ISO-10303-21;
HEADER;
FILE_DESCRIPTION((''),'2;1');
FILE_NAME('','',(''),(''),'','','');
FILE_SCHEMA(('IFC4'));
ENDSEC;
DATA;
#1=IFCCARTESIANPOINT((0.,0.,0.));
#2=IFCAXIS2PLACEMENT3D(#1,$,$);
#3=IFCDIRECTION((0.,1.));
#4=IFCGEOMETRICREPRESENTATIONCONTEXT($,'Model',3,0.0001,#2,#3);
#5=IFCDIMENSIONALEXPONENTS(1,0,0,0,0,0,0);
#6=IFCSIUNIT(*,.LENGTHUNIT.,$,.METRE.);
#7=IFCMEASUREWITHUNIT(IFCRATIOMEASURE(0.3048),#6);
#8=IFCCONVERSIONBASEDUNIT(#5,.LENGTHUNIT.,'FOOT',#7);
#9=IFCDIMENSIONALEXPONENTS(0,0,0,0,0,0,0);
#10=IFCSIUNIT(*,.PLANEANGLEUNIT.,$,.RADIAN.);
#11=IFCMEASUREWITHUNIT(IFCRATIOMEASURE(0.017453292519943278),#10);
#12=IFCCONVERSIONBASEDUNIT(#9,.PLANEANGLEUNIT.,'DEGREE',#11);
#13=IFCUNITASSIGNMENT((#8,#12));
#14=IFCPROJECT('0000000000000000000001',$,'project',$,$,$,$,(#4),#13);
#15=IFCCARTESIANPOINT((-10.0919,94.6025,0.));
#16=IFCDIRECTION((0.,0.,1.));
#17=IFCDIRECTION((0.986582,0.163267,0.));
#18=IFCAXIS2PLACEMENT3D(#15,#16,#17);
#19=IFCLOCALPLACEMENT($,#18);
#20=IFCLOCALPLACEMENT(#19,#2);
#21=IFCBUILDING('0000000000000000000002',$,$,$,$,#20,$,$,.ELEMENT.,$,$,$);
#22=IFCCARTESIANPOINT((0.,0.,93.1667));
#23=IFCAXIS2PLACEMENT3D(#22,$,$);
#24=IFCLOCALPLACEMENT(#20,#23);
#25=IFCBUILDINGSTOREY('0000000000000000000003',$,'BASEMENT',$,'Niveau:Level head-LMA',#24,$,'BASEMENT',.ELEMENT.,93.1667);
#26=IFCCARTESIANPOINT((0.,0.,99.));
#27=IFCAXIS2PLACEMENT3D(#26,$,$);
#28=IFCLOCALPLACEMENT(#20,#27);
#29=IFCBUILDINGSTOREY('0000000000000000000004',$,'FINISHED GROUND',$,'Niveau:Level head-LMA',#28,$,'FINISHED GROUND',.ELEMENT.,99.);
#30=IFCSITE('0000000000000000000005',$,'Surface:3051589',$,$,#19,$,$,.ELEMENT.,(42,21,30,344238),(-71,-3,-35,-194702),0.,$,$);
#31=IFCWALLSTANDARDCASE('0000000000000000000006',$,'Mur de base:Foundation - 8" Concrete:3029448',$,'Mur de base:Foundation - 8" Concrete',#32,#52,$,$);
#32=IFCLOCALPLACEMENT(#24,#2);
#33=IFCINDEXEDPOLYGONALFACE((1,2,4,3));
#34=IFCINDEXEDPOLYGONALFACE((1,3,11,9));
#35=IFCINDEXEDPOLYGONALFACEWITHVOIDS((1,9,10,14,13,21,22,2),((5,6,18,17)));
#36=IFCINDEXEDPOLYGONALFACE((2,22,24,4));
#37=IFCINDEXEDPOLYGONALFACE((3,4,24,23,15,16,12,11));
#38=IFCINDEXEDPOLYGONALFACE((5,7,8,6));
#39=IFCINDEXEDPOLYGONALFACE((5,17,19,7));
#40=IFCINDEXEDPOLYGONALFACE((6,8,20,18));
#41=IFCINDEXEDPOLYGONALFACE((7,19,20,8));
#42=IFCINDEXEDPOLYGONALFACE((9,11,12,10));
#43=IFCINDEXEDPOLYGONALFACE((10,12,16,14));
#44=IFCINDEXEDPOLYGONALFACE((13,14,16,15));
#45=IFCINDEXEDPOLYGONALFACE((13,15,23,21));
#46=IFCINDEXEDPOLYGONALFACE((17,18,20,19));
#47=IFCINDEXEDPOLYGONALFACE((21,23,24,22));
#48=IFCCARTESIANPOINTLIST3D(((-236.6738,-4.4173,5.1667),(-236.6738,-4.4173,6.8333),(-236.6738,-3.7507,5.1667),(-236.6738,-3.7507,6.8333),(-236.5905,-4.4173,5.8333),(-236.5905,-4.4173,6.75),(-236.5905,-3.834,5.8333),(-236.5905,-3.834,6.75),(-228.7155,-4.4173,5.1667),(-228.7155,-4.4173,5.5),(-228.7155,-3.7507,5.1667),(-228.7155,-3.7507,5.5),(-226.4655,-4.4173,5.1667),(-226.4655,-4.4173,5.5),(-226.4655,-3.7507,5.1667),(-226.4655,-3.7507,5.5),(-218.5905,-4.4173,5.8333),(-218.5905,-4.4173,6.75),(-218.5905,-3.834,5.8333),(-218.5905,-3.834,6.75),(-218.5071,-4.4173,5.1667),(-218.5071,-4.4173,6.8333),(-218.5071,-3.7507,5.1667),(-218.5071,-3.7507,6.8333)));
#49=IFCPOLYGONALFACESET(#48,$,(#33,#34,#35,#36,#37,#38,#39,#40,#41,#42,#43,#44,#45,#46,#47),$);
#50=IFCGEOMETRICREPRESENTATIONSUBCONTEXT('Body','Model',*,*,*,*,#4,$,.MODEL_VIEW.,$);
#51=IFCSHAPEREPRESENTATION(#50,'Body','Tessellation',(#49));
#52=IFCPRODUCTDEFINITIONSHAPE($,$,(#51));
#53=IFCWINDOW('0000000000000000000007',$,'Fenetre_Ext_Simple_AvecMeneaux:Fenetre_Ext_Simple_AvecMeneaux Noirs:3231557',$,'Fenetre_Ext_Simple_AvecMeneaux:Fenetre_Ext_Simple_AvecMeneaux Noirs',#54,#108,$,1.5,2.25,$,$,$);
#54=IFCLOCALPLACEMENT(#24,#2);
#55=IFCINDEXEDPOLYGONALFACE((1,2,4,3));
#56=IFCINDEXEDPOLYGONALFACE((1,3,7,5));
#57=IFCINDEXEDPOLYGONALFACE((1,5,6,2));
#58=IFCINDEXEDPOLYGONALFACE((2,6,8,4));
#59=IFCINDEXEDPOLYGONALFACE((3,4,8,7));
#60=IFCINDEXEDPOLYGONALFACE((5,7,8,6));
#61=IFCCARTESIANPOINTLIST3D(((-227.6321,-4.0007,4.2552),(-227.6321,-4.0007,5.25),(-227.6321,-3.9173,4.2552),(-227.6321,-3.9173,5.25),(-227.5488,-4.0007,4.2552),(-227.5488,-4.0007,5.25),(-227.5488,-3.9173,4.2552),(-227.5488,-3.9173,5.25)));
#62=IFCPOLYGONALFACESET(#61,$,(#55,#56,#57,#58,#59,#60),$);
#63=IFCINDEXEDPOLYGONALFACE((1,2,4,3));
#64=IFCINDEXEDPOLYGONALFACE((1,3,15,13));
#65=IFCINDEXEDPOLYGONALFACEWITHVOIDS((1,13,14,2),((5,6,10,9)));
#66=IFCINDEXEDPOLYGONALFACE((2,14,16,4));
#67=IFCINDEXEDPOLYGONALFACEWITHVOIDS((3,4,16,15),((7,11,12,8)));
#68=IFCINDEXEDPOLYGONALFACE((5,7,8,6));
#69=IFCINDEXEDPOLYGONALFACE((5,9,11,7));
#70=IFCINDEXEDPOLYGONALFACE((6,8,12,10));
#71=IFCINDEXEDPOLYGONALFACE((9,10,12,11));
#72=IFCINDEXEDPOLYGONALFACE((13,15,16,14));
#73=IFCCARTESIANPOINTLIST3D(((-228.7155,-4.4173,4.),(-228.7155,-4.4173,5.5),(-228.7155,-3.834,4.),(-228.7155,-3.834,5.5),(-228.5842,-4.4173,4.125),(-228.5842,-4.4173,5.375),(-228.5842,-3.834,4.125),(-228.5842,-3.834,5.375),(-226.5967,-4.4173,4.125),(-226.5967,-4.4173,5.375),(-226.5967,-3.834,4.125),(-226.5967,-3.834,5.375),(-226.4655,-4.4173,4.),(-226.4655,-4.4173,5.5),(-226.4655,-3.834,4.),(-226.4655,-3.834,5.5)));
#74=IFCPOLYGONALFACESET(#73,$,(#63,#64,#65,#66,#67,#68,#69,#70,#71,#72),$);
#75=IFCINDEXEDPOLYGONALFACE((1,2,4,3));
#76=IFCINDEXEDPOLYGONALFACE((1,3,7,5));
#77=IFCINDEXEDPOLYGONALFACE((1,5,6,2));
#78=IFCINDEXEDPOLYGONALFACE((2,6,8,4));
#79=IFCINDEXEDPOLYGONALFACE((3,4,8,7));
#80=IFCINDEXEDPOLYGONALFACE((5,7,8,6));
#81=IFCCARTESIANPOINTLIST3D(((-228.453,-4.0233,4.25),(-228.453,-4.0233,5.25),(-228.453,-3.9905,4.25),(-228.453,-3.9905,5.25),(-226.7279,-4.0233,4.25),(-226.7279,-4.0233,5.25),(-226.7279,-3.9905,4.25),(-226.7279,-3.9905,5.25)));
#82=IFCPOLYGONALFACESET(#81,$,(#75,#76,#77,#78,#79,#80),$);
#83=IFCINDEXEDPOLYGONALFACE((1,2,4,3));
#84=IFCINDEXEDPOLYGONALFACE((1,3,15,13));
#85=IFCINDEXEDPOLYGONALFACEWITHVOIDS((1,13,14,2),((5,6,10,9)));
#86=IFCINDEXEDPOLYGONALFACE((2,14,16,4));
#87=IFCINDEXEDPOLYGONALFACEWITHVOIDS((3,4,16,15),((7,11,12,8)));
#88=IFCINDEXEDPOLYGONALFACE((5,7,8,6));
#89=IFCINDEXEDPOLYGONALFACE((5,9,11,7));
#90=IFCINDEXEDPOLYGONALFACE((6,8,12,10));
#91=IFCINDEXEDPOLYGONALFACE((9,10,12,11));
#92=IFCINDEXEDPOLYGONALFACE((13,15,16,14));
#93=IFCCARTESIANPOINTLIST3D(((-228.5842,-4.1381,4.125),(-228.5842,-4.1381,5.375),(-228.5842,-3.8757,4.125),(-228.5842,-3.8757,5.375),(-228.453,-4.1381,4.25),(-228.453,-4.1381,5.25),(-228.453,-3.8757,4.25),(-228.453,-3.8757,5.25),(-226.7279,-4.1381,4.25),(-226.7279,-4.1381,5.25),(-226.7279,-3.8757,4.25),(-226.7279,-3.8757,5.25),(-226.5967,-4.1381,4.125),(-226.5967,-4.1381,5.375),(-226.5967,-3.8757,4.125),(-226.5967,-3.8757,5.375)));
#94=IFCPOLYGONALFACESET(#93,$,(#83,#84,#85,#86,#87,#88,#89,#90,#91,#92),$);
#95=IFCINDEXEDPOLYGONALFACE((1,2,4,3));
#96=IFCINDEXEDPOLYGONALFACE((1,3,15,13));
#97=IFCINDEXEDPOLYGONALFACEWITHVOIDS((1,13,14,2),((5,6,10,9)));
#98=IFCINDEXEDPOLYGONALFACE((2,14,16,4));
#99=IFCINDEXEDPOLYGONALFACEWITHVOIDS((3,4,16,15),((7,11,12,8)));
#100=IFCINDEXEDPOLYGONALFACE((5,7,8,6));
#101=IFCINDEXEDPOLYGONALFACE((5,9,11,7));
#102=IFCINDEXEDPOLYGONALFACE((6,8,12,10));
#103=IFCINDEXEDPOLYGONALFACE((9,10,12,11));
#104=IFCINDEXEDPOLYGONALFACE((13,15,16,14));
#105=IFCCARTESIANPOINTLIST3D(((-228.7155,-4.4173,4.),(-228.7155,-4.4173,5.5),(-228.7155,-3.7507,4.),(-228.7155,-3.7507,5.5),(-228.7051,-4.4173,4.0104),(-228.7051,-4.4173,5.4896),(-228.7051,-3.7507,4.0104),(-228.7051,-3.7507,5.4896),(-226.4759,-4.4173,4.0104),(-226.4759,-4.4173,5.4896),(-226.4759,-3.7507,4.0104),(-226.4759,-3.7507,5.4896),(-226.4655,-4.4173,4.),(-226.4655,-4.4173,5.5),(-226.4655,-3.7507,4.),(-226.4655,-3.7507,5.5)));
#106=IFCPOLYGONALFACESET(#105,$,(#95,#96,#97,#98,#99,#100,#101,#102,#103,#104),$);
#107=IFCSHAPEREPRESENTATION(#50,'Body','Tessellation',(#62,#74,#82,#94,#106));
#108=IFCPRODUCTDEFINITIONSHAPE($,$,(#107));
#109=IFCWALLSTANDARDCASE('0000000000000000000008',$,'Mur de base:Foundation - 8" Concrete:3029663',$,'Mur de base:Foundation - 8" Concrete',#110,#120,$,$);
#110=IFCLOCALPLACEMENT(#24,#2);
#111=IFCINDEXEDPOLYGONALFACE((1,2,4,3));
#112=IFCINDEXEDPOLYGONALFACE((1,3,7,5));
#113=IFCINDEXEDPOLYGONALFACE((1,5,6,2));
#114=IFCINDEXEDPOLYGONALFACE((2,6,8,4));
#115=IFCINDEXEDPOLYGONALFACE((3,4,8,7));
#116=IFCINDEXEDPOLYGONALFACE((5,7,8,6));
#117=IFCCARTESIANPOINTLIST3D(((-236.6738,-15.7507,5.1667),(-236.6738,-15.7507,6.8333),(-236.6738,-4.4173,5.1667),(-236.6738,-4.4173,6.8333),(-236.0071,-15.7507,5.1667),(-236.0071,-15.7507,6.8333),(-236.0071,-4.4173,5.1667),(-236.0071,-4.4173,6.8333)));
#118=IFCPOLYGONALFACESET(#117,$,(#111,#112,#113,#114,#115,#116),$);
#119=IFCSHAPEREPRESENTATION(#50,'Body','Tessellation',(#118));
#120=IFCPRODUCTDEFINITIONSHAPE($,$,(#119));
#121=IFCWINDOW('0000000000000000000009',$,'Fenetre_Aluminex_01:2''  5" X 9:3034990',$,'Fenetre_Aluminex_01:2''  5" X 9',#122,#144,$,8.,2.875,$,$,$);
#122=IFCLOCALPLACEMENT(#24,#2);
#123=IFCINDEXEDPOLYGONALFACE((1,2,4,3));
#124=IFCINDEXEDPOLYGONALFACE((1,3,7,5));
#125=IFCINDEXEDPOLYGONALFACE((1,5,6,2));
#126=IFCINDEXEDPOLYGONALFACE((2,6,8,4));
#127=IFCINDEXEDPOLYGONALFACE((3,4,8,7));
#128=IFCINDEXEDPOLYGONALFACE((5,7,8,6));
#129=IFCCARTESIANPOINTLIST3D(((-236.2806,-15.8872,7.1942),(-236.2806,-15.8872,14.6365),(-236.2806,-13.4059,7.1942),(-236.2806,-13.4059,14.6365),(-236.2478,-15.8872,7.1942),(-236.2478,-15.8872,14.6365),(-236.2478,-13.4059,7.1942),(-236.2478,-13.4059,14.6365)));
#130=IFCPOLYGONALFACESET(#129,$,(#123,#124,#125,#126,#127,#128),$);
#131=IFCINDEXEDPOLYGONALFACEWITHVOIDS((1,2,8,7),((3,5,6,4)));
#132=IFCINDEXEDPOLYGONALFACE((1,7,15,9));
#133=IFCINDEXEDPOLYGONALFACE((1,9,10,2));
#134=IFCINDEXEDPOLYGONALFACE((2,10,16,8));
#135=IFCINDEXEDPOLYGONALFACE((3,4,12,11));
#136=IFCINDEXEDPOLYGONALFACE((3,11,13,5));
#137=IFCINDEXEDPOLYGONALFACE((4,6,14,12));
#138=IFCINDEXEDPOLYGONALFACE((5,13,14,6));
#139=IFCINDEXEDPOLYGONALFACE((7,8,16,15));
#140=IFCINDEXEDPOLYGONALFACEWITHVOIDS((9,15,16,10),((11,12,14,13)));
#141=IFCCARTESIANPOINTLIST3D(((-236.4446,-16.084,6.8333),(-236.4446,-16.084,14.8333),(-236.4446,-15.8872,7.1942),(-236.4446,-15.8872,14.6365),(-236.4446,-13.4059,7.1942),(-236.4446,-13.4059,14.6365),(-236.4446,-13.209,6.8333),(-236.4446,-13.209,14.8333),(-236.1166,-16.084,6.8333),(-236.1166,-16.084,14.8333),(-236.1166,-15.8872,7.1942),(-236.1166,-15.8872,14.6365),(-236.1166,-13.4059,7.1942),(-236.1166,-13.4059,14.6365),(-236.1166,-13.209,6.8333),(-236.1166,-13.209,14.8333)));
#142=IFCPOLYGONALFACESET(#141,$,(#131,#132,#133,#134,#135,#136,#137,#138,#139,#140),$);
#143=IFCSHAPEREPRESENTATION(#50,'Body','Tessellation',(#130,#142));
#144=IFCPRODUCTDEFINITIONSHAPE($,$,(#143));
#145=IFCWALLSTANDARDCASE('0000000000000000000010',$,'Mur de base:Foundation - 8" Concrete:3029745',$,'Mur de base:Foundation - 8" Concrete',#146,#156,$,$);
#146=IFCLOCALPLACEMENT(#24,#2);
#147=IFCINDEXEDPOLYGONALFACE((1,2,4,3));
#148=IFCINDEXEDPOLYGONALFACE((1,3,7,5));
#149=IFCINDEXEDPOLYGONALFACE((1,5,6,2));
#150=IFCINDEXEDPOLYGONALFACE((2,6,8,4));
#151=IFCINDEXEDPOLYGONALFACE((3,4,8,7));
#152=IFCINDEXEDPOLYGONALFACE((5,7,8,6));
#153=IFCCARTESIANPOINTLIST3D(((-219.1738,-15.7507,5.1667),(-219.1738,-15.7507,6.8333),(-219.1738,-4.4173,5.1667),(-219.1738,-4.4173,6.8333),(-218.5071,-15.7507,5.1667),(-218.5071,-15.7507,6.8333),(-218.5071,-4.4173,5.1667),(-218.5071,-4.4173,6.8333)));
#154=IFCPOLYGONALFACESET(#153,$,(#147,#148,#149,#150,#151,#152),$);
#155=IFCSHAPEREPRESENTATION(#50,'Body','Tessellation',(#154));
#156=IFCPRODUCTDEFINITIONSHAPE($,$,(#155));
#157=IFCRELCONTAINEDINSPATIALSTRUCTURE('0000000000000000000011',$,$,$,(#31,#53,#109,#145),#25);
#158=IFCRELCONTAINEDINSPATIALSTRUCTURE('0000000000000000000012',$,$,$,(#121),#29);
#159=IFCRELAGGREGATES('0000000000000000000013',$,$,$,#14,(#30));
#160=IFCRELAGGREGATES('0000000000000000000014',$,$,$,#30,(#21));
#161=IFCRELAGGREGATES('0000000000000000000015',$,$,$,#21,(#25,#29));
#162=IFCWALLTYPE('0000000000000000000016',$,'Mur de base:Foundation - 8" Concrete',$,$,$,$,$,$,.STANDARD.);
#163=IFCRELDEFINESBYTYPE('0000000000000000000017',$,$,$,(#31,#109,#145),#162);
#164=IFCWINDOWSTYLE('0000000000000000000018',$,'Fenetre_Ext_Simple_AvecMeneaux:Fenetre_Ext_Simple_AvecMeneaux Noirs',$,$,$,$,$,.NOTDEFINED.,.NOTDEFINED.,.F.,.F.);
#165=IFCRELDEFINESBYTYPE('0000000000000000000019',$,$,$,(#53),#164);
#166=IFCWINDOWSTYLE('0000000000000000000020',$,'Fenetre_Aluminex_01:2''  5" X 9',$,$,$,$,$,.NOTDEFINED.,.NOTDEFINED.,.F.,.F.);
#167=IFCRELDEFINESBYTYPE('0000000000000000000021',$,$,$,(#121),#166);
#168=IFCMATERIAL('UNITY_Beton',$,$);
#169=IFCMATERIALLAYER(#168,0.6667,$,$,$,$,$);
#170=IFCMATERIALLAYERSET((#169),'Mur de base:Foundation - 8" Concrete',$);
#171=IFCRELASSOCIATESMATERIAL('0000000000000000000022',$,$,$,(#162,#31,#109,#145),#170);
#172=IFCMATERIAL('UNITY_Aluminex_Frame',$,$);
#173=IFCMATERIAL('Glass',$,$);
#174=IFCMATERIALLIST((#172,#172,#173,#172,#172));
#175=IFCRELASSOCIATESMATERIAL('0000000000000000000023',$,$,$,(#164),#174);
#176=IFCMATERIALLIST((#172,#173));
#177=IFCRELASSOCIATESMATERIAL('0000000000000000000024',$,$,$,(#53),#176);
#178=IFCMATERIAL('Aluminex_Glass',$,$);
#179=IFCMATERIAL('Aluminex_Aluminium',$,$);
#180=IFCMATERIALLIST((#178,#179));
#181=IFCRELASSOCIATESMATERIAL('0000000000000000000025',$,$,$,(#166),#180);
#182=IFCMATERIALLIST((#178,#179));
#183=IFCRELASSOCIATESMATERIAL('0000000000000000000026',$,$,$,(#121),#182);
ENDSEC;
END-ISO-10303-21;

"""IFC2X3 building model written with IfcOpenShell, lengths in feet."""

from ifc_helpers import new_model, entity, si_unit, converted_unit, direction, frame, frame_2d, origin, place, context, subcontext, project, spatial, polyline, rectangle, outline, extrude, source, transform, mapped, material, material_list, layer, layer_set, layer_usage, type_object, type_shapes, element, fill, save


model = new_model("IFC2X3")

# Units and contexts
model_context = context("Model", 3, precision=0.0001, world=origin(), true_north=direction((0.0, 1.0)))
body_context = subcontext(model_context, "Body", "Model", "MODEL_VIEW")
ifc_project = project(units=[converted_unit("LENGTHUNIT", "FOOT", entity("IfcRatioMeasure", 0.3048), si_unit("LENGTHUNIT", "METRE"), dimensions=[1, 0, 0, 0, 0, 0, 0]), converted_unit("PLANEANGLEUNIT", "DEGREE", entity("IfcRatioMeasure", 0.017453292519943278), si_unit("PLANEANGLEUNIT", "RADIAN"), dimensions=[0, 0, 0, 0, 0, 0, 0])], contexts=[model_context])

# Site, building, storey
site_placement = place(None, frame((-10.0919, 94.6025, 0.0), z_axis=(0.0, 0.0, 1.0), x_axis=(0.986582, 0.163267, 0.0)))
site = spatial("IfcSite", under=ifc_project, at=site_placement, Name="Surface:3051589", CompositionType="ELEMENT", RefLatitude=(42, 21, 30, 344238), RefLongitude=(-71, -3, -35, -194702), RefElevation=0.0)
building_placement = place(site_placement, origin())
building = spatial("IfcBuilding", under=site, at=building_placement, CompositionType="ELEMENT")
storey_1_placement = place(building_placement, frame((0.0, 0.0, 93.1667)))
storey_1 = spatial("IfcBuildingStorey", under=building, at=storey_1_placement, Name="BASEMENT", ObjectType="Niveau:Level head-LMA", LongName="BASEMENT", CompositionType="ELEMENT", Elevation=93.1667)

# Wall, openings, window
ifc_material_1 = material(Name="UNITY_Beton")
ifc_layer = layer(ifc_material_1, 0.6667)
ifc_layer_set = layer_set([ifc_layer], Name="Mur de base:Foundation - 8\" Concrete")
ifc_layer_usage_1 = layer_usage(ifc_layer_set, "AXIS2", "POSITIVE", -0.3333)
wall_type = type_object("IfcWallType", Name="Mur de base:Foundation - 8\" Concrete", PredefinedType="STANDARD", material=ifc_layer_set)
wall_1_placement = place(storey_1_placement, frame((-218.5071, -4.084, 5.1667), z_axis=(0.0, 0.0, 1.0), x_axis=(-1.0, 0.0, 0.0)))
wall_1 = element("IfcWallStandardCase", 1, at=wall_1_placement, inside=storey_1, type_object=wall_type, material=ifc_layer_usage_1, Name="Mur de base:Foundation - 8\" Concrete:3029448", ObjectType="Mur de base:Foundation - 8\" Concrete", context=body_context, shape_type="SweptSolid", body=[
    extrude(rectangle(XDim=18.1667, YDim=0.6667, at=frame_2d((9.0833, 0.0), x_axis=(-1.0, 0.0))), origin(), (0.0, 0.0, 1.0), 1.6667),
])
opening_1_placement = place(storey_1_placement, frame((-218.5071, -4.084, 5.1667), z_axis=(0.0, 0.0, 1.0), x_axis=(-1.0, 0.0, 0.0)))
element("IfcOpeningElement", 2, at=opening_1_placement, cuts=wall_1, ObjectType="Opening", context=body_context, shape_type="SweptSolid", body=[
    extrude(rectangle(XDim=18.0, YDim=0.5833, at=frame_2d((0.0, 0.0), x_axis=(1.0, 0.0))), frame((9.0834, 0.0417, 0.6667)), (0.0, 0.0, 1.0), 0.9167),
])
opening_2_placement = place(wall_1_placement, frame((10.2083, 0.3333, -1.1667)))
opening_2 = element("IfcOpeningElement", 3, at=opening_2_placement, cuts=wall_1, ObjectType="Opening", context=body_context, shape_type="SweptSolid", body=[
    extrude(rectangle(XDim=1.5, YDim=2.25, at=frame_2d((0.75, 1.125), x_axis=(1.0, 0.0))), frame((0.0, 0.0, 0.0), z_axis=(0.0, -1.0, 0.0), x_axis=(0.0, 0.0, 1.0)), (0.0, 0.0, 1.0), 0.6667),
])
ifc_material_2 = material(Name="UNITY_Aluminex_Frame")
ifc_material_3 = material(Name="Glass")
ifc_material_list_1 = material_list([ifc_material_2, ifc_material_3])
ifc_material_list_2 = material_list([ifc_material_2, ifc_material_2, ifc_material_3, ifc_material_2, ifc_material_2])
window_style_1 = type_object("IfcWindowStyle", Name="Fenetre_Ext_Simple_AvecMeneaux:Fenetre_Ext_Simple_AvecMeneaux Noirs", ConstructionType="NOTDEFINED", OperationType="NOTDEFINED", ParameterTakesPrecedence=False, Sizeable=False, material=ifc_material_list_2)
shared_shape_1 = source(origin(), body_context, "Body", "SweptSolid", [
    extrude(rectangle(XDim=0.0833, YDim=0.0833, at=frame_2d((0.0, 0.0), x_axis=(1.0, 0.0))), frame((1.125, 0.4583, 0.2552), z_axis=(0.0, 0.0, 1.0), x_axis=(0.0, -1.0, 0.0)), (0.0, 0.0, 1.0), 0.9948),
    extrude(outline(polyline([(-0.75, -1.125), (0.75, -1.125), (0.75, 1.125), (-0.75, 1.125), (-0.75, -1.125)]), holes=[polyline([(-0.625, 0.9938), (0.625, 0.9938), (0.625, -0.9938), (-0.625, -0.9938), (-0.625, 0.9938)])]), frame((1.125, 0.0, 0.75), z_axis=(0.0, 1.0, 0.0), x_axis=(0.0, 0.0, -1.0)), (0.0, 0.0, 1.0), 0.5833),
    extrude(rectangle(XDim=0.0328, YDim=1.7251, at=frame_2d((0.0, 0.0), x_axis=(1.0, 0.0))), frame((1.125, 0.4104, 0.25), z_axis=(0.0, 0.0, 1.0), x_axis=(0.0, 1.0, 0.0)), (0.0, 0.0, 1.0), 1.0),
    extrude(outline(polyline([(-0.9938, -0.625), (0.9938, -0.625), (0.9938, 0.625), (-0.9938, 0.625), (-0.9938, -0.625)]), holes=[polyline([(-0.8625, -0.5), (-0.8625, 0.5), (0.8625, 0.5), (0.8625, -0.5), (-0.8625, -0.5)])]), frame((1.125, 0.2792, 0.75), z_axis=(0.0, 1.0, 0.0), x_axis=(1.0, 0.0, 0.0)), (0.0, 0.0, 1.0), 0.2625),
    extrude(outline(polyline([(-1.125, -0.75), (1.125, -0.75), (1.125, 0.75), (-1.125, 0.75), (-1.125, -0.75)]), holes=[polyline([(1.1146, -0.7396), (-1.1146, -0.7396), (-1.1146, 0.7396), (1.1146, 0.7396), (1.1146, -0.7396)])]), frame((1.125, 0.0, 0.75), z_axis=(0.0, 1.0, 0.0), x_axis=(1.0, 0.0, 0.0)), (0.0, 0.0, 1.0), 0.6667),
])
type_shapes(window_style_1, [shared_shape_1])
window_1_placement = place(opening_2_placement, frame((0.0, 0.0, 0.0), z_axis=(0.0, 0.0, 1.0), x_axis=(-1.0, 0.0, 0.0)))
window_1 = element("IfcWindow", 4, at=window_1_placement, inside=storey_1, type_object=window_style_1, material=ifc_material_list_1, Name="Fenetre_Ext_Simple_AvecMeneaux:Fenetre_Ext_Simple_AvecMeneaux Noirs:3231557", ObjectType="Fenetre_Ext_Simple_AvecMeneaux:Fenetre_Ext_Simple_AvecMeneaux Noirs", OverallHeight=1.5, OverallWidth=2.25, context=body_context, shape_type="MappedRepresentation", body=[
    mapped(shared_shape_1, transform((0.0, 0.0, 0.0), scale=1.0)),
])
fill(opening_2, window_1)

# Wall, opening
ifc_layer_usage_2 = layer_usage(ifc_layer_set, "AXIS2", "NEGATIVE", 0.3333)
wall_2_placement = place(storey_1_placement, frame((-236.3405, -15.7507, 5.1667), z_axis=(0.0, 0.0, 1.0), x_axis=(0.0, 1.0, 0.0)))
wall_2 = element("IfcWallStandardCase", 5, at=wall_2_placement, inside=storey_1, type_object=wall_type, material=ifc_layer_usage_2, Name="Mur de base:Foundation - 8\" Concrete:3029663", ObjectType="Mur de base:Foundation - 8\" Concrete", context=body_context, shape_type="SweptSolid", body=[
    extrude(rectangle(XDim=11.3333, YDim=0.6667, at=frame_2d((5.6667, 0.0), x_axis=(-1.0, 0.0))), origin(), (0.0, 0.0, 1.0), 1.6667),
])
opening_3_placement = place(wall_2_placement, frame((-0.3333, -0.3333, 1.6667)))
opening_3 = element("IfcOpeningElement", 6, at=opening_3_placement, cuts=wall_2, ObjectType="Opening", context=body_context, shape_type="SweptSolid", body=[
    extrude(rectangle(XDim=8.0, YDim=2.875, at=frame_2d((4.0, 1.4375), x_axis=(1.0, 0.0))), frame((0.0, 0.0, 0.0), z_axis=(0.0, 1.0, 0.0), x_axis=(0.0, 0.0, 1.0)), (0.0, 0.0, 1.0), 0.6667),
])

# Shared definitions
storey_2_placement = place(building_placement, frame((0.0, 0.0, 99.0)))
storey_2 = spatial("IfcBuildingStorey", under=building, at=storey_2_placement, Name="FINISHED GROUND", ObjectType="Niveau:Level head-LMA", LongName="FINISHED GROUND", CompositionType="ELEMENT", Elevation=99.0)

# Window
ifc_material_4 = material(Name="Aluminex_Glass")
ifc_material_5 = material(Name="Aluminex_Aluminium")
ifc_material_list_3 = material_list([ifc_material_4, ifc_material_5])
ifc_material_list_4 = material_list([ifc_material_4, ifc_material_5])
window_style_2 = type_object("IfcWindowStyle", Name="Fenetre_Aluminex_01:2'  5\" X 9", ConstructionType="NOTDEFINED", OperationType="NOTDEFINED", ParameterTakesPrecedence=False, Sizeable=False, material=ifc_material_list_4)
shared_shape_2 = source(origin(), body_context, "Body", "SweptSolid", [
    extrude(rectangle(XDim=0.0328, YDim=2.4813, at=frame_2d((0.0, 0.0), x_axis=(1.0, 0.0))), frame((1.4375, 0.2571, 0.3609), z_axis=(0.0, 0.0, 1.0), x_axis=(0.0, 1.0, 0.0)), (0.0, 0.0, 1.0), 7.4423),
    extrude(outline(polyline([(-1.4375, -4.0), (1.4375, -4.0), (1.4375, 4.0), (-1.4375, 4.0), (-1.4375, -4.0)]), holes=[polyline([(-1.2406, -3.8031), (-1.2406, 3.6391), (1.2406, 3.6391), (1.2406, -3.8031), (-1.2406, -3.8031)])]), frame((1.4375, 0.1094, 4.0), z_axis=(0.0, 1.0, 0.0), x_axis=(1.0, 0.0, 0.0)), (0.0, 0.0, 1.0), 0.3281),
])
type_shapes(window_style_2, [shared_shape_2])
window_2_placement = place(opening_3_placement, origin())
window_2 = element("IfcWindow", 7, at=window_2_placement, inside=storey_2, type_object=window_style_2, material=ifc_material_list_3, Name="Fenetre_Aluminex_01:2'  5\" X 9:3034990", ObjectType="Fenetre_Aluminex_01:2'  5\" X 9", OverallHeight=8.0, OverallWidth=2.875, context=body_context, shape_type="MappedRepresentation", body=[
    mapped(shared_shape_2, transform((0.0, 0.0, 0.0), scale=1.0)),
])
fill(opening_3, window_2)

# Wall
ifc_layer_usage_3 = layer_usage(ifc_layer_set, "AXIS2", "POSITIVE", -0.3333)
wall_3_placement = place(storey_1_placement, frame((-218.8405, -15.7507, 5.1667), z_axis=(0.0, 0.0, 1.0), x_axis=(0.0, 1.0, 0.0)))
element("IfcWallStandardCase", 8, at=wall_3_placement, inside=storey_1, type_object=wall_type, material=ifc_layer_usage_3, Name="Mur de base:Foundation - 8\" Concrete:3029745", ObjectType="Mur de base:Foundation - 8\" Concrete", context=body_context, shape_type="SweptSolid", body=[
    extrude(rectangle(XDim=11.3333, YDim=0.6667, at=frame_2d((5.6667, 0.0), x_axis=(-1.0, 0.0))), origin(), (0.0, 0.0, 1.0), 1.6667),
])

save(model, "model.ifc")
